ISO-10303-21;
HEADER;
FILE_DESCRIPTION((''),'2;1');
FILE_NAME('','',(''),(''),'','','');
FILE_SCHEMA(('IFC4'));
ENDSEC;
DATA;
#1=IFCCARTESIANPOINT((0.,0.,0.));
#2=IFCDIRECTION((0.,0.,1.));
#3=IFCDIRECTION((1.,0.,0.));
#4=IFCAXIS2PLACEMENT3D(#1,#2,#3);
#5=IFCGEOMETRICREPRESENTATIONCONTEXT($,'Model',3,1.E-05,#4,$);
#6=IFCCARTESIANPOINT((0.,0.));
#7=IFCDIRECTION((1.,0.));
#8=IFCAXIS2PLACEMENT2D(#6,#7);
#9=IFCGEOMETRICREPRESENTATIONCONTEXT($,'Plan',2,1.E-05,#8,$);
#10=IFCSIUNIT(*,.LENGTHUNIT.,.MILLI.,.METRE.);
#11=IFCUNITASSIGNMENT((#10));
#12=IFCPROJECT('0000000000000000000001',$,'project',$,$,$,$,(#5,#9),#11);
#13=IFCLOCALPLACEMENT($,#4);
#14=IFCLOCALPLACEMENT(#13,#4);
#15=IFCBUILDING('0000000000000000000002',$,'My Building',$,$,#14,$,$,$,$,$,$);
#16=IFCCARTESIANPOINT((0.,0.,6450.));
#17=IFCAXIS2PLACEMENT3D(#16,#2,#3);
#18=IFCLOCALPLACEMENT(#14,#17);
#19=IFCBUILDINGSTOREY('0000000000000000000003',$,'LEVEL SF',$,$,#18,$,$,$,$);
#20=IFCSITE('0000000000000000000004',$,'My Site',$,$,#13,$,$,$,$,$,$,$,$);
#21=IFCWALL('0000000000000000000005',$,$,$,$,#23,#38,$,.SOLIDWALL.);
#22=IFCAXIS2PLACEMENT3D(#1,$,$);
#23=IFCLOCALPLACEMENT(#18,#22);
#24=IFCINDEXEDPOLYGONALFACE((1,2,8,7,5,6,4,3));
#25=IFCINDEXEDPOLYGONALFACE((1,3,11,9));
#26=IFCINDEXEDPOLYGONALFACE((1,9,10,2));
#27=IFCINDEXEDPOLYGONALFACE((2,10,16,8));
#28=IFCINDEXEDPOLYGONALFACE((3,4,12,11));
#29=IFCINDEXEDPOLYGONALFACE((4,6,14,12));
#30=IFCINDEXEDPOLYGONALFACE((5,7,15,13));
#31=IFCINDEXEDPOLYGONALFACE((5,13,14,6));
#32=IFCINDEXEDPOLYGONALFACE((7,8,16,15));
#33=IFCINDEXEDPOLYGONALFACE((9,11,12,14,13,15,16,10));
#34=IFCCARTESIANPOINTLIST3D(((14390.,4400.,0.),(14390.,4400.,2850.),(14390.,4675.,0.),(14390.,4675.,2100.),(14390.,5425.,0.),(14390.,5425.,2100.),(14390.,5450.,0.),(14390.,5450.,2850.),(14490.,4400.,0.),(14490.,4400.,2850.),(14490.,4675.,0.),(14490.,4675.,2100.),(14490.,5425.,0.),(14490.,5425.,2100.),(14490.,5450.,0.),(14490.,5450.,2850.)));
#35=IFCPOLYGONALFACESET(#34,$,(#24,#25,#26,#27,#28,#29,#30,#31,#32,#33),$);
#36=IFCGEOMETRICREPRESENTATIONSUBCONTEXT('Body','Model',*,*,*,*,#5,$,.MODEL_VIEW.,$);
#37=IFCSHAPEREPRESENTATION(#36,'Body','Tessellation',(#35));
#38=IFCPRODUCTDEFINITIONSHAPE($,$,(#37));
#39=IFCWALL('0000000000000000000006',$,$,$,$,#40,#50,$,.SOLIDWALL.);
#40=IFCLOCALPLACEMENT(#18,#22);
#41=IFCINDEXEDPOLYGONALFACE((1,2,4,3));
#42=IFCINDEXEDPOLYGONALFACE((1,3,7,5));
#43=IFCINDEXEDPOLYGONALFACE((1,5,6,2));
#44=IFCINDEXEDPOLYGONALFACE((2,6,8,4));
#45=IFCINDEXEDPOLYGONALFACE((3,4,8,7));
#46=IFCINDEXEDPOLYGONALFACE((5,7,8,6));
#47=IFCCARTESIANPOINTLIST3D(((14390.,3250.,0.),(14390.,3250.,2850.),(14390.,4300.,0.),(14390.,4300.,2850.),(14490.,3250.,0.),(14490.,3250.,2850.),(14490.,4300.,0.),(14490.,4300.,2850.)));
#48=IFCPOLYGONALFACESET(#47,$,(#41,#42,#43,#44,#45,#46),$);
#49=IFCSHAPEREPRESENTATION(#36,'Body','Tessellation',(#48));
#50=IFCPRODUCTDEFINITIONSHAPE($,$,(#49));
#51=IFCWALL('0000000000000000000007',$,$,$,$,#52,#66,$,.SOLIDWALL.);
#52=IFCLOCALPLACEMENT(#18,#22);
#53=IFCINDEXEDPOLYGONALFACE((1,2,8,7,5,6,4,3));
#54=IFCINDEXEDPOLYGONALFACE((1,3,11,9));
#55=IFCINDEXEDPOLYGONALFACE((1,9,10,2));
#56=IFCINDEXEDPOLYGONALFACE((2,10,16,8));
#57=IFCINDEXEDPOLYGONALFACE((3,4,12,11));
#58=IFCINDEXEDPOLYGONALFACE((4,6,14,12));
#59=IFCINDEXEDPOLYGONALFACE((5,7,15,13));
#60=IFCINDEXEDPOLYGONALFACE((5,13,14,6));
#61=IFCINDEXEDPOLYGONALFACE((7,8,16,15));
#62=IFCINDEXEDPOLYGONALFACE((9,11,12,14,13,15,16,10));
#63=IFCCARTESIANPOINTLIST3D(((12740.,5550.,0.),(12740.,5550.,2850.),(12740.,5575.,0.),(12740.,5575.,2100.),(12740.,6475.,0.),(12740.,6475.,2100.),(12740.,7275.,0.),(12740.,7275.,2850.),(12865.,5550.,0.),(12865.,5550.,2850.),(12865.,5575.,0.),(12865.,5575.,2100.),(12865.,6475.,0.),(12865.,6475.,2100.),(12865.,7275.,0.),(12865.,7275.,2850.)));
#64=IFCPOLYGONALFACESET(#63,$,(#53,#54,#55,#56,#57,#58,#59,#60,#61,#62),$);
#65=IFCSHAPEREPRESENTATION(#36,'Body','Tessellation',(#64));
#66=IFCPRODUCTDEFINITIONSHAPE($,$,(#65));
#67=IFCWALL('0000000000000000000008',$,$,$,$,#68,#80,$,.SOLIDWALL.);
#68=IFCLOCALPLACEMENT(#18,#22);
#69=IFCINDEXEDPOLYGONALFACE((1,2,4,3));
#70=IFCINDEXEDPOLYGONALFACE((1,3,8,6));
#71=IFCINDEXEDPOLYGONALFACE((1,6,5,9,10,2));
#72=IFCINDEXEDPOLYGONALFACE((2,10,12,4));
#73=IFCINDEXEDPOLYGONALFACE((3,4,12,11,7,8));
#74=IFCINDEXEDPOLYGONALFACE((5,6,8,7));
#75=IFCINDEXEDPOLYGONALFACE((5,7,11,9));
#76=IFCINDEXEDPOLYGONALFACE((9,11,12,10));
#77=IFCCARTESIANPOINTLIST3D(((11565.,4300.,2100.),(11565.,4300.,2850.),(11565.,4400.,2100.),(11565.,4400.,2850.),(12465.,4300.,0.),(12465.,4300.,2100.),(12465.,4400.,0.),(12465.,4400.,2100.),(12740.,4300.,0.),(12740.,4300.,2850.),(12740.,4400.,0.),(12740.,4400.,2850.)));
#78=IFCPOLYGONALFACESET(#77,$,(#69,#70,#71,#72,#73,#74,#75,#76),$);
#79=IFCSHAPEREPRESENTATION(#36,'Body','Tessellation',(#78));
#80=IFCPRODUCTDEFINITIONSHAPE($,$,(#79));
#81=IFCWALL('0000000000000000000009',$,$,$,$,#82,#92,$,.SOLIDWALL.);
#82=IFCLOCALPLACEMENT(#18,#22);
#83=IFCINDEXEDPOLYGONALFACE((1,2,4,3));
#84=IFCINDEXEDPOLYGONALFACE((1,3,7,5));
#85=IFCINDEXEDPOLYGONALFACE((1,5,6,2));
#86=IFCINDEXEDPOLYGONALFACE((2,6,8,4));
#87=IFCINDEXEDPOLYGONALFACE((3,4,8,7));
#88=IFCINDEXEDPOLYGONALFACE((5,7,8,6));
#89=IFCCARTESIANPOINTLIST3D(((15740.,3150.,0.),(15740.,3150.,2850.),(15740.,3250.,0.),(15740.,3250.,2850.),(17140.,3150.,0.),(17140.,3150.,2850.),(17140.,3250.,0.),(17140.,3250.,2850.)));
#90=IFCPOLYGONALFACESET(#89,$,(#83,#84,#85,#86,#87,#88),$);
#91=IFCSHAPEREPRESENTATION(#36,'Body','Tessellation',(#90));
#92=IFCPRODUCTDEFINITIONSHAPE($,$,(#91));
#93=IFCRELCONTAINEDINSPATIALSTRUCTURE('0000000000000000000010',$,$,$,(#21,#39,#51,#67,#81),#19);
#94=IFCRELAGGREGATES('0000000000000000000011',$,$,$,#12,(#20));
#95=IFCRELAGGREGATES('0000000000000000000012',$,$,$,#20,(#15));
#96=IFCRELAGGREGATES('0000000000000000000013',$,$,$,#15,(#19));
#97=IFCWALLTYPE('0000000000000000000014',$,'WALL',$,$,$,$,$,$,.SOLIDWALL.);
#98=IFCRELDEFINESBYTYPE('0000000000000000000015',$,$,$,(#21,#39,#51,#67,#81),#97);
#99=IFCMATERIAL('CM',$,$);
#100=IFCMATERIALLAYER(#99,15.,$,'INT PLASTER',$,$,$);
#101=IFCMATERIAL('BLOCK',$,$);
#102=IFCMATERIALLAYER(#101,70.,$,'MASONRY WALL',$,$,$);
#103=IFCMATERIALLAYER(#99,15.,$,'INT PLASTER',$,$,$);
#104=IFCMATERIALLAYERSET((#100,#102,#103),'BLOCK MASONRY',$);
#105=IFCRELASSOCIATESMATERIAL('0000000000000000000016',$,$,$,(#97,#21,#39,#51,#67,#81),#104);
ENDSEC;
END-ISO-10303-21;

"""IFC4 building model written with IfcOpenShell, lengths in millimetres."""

from ifc_helpers import new_model, si_unit, frame, origin_with_axes, origin_2d_with_axis, place, context, subcontext, project, spatial, indexed_curve, outline, extrude, material, layer, layer_set, layer_usage, type_object, element, save


model = new_model("IFC4")

# Units and contexts
model_context = context("Model", 3, precision=1e-05, world=origin_with_axes())
plan_context = context("Plan", 2, precision=1e-05, world=origin_2d_with_axis())
body_context = subcontext(model_context, "Body", "Model", "MODEL_VIEW")
ifc_project = project(units=[si_unit("LENGTHUNIT", "METRE", prefix="MILLI")], contexts=[model_context, plan_context])

# Site, building, storey
site_placement = place(None, origin_with_axes())
site = spatial("IfcSite", under=ifc_project, at=site_placement, Name="My Site")
building_placement = place(site_placement, origin_with_axes())
building = spatial("IfcBuilding", under=site, at=building_placement, Name="My Building")
storey_placement = place(building_placement, frame((0.0, 0.0, 6450.0), z_axis=(0.0, 0.0, 1.0), x_axis=(1.0, 0.0, 0.0)))
storey = spatial("IfcBuildingStorey", under=building, at=storey_placement, Name="LEVEL SF")

# Shared definitions
ifc_material_1 = material(Name="CM")
ifc_layer_1 = layer(ifc_material_1, 15.0, Name="INT PLASTER")
ifc_material_2 = material(Name="BLOCK")
ifc_layer_2 = layer(ifc_material_2, 70.0, Name="MASONRY WALL")
ifc_layer_3 = layer(ifc_material_1, 15.0, Name="INT PLASTER")
ifc_layer_set = layer_set([ifc_layer_1, ifc_layer_2, ifc_layer_3], Name="BLOCK MASONRY")
wall_type = type_object("IfcWallType", Name="WALL", PredefinedType="SOLIDWALL", material=ifc_layer_set)

# Wall, opening
ifc_layer_usage_1 = layer_usage(ifc_layer_set, "AXIS2", "POSITIVE", 0.0)
wall_1_placement = place(storey_placement, frame((14490.0, 4400.0, 0.0), z_axis=(0.0, 0.0, 1.0), x_axis=(0.0, 1.0, 0.0)))
wall_1 = element("IfcWall", 1, at=wall_1_placement, inside=storey, type_object=wall_type, material=ifc_layer_usage_1, PredefinedType="SOLIDWALL", context=body_context, shape_type="SweptSolid", body=[
    extrude(outline(indexed_curve([(0.0, 0.0), (0.0, 100.0), (1050.0, 100.0), (1050.0, 0.0), (0.0, 0.0)], self_intersect=False)), origin_with_axes(), (0.0, 0.0, 1.0), 2850.0),
])
opening_1_placement = place(wall_1_placement, frame((275.0, 0.0, 0.0), z_axis=(0.0, 0.0, 1.0), x_axis=(1.0, 0.0, 0.0)))
element("IfcOpeningElement", 2, at=opening_1_placement, cuts=wall_1, PredefinedType="OPENING", context=body_context, shape_type="SweptSolid", body=[
    extrude(outline(indexed_curve([(0.0, 0.0), (0.0, 400.0), (750.0, 400.0), (750.0, 0.0), (0.0, 0.0)], self_intersect=False)), frame((0.0, -100.0, 0.0), z_axis=(0.0, 0.0, 1.0), x_axis=(1.0, 0.0, 0.0)), (0.0, 0.0, 1.0), 2100.0),
])

# Wall
ifc_layer_usage_2 = layer_usage(ifc_layer_set, "AXIS2", "POSITIVE", 0.0)
wall_2_placement = place(storey_placement, frame((14490.0, 3250.0, 0.0), z_axis=(0.0, 0.0, 1.0), x_axis=(0.0, 1.0, 0.0)))
element("IfcWall", 3, at=wall_2_placement, inside=storey, type_object=wall_type, material=ifc_layer_usage_2, PredefinedType="SOLIDWALL", context=body_context, shape_type="SweptSolid", body=[
    extrude(outline(indexed_curve([(0.0, 0.0), (0.0, 100.0), (1050.0, 100.0), (1050.0, 0.0), (0.0, 0.0)], self_intersect=False)), origin_with_axes(), (0.0, 0.0, 1.0), 2850.0),
])

# Walls, openings
ifc_layer_usage_3 = layer_usage(ifc_layer_set, "AXIS2", "POSITIVE", 0.0)
wall_3_placement = place(storey_placement, frame((12865.0, 5550.0, 0.0), z_axis=(0.0, 0.0, 1.0), x_axis=(0.0, 1.0, 0.0)))
wall_3 = element("IfcWall", 4, at=wall_3_placement, inside=storey, type_object=wall_type, material=ifc_layer_usage_3, PredefinedType="SOLIDWALL", context=body_context, shape_type="SweptSolid", body=[
    extrude(outline(indexed_curve([(0.0, 0.0), (0.0, 125.0), (1725.0, 125.0), (1725.0, 0.0), (0.0, 0.0)], self_intersect=False)), origin_with_axes(), (0.0, 0.0, 1.0), 2850.0),
])
opening_2_placement = place(wall_3_placement, frame((925.0, 125.0, 0.0), z_axis=(0.0, 0.0, 1.0), x_axis=(-1.0, 0.0, 0.0)))
element("IfcOpeningElement", 5, at=opening_2_placement, cuts=wall_3, PredefinedType="OPENING", context=body_context, shape_type="SweptSolid", body=[
    extrude(outline(indexed_curve([(0.0, 0.0), (0.0, 400.0), (900.0, 400.0), (900.0, 0.0), (0.0, 0.0)], self_intersect=False)), frame((0.0, -100.0, 0.0), z_axis=(0.0, 0.0, 1.0), x_axis=(1.0, 0.0, 0.0)), (0.0, 0.0, 1.0), 2100.0),
])
ifc_layer_usage_4 = layer_usage(ifc_layer_set, "AXIS2", "POSITIVE", 0.0)
wall_4_placement = place(storey_placement, frame((11565.0, 4400.0, 0.0), z_axis=(0.0, 0.0, 1.0), x_axis=(0.0, -1.0, 0.0)))
wall_4 = element("IfcWall", 6, at=wall_4_placement, inside=storey, type_object=wall_type, material=ifc_layer_usage_4, PredefinedType="SOLIDWALL", context=body_context, shape_type="SweptSolid", body=[
    extrude(outline(indexed_curve([(0.0, 0.0), (0.0, 1175.0), (100.0, 1175.0), (100.0, 0.0), (0.0, 0.0)], self_intersect=False)), origin_with_axes(), (0.0, 0.0, 1.0), 2850.0),
])
opening_3_placement = place(wall_4_placement, frame((0.0, 900.0, 0.0), z_axis=(0.0, 0.0, 1.0), x_axis=(0.0, -1.0, 0.0)))
element("IfcOpeningElement", 7, at=opening_3_placement, cuts=wall_4, PredefinedType="OPENING", context=body_context, shape_type="SweptSolid", body=[
    extrude(outline(indexed_curve([(0.0, 0.0), (0.0, 400.0), (900.0, 400.0), (900.0, 0.0), (0.0, 0.0)], self_intersect=False)), frame((0.0, -100.0, 0.0), z_axis=(0.0, 0.0, 1.0), x_axis=(1.0, 0.0, 0.0)), (0.0, 0.0, 1.0), 2100.0),
])

# Wall
ifc_layer_usage_5 = layer_usage(ifc_layer_set, "AXIS2", "POSITIVE", 0.0)
wall_5_placement = place(storey_placement, frame((15740.0, 3250.0, 0.0), z_axis=(0.0, 0.0, 1.0), x_axis=(0.0, -1.0, 0.0)))
element("IfcWall", 8, at=wall_5_placement, inside=storey, type_object=wall_type, material=ifc_layer_usage_5, PredefinedType="SOLIDWALL", context=body_context, shape_type="SweptSolid", body=[
    extrude(outline(indexed_curve([(0.0, 0.0), (0.0, 1400.0), (100.0, 1400.0), (100.0, 0.0), (0.0, 0.0)], self_intersect=False)), origin_with_axes(), (0.0, 0.0, 1.0), 2850.0),
])

save(model, "model.ifc")
